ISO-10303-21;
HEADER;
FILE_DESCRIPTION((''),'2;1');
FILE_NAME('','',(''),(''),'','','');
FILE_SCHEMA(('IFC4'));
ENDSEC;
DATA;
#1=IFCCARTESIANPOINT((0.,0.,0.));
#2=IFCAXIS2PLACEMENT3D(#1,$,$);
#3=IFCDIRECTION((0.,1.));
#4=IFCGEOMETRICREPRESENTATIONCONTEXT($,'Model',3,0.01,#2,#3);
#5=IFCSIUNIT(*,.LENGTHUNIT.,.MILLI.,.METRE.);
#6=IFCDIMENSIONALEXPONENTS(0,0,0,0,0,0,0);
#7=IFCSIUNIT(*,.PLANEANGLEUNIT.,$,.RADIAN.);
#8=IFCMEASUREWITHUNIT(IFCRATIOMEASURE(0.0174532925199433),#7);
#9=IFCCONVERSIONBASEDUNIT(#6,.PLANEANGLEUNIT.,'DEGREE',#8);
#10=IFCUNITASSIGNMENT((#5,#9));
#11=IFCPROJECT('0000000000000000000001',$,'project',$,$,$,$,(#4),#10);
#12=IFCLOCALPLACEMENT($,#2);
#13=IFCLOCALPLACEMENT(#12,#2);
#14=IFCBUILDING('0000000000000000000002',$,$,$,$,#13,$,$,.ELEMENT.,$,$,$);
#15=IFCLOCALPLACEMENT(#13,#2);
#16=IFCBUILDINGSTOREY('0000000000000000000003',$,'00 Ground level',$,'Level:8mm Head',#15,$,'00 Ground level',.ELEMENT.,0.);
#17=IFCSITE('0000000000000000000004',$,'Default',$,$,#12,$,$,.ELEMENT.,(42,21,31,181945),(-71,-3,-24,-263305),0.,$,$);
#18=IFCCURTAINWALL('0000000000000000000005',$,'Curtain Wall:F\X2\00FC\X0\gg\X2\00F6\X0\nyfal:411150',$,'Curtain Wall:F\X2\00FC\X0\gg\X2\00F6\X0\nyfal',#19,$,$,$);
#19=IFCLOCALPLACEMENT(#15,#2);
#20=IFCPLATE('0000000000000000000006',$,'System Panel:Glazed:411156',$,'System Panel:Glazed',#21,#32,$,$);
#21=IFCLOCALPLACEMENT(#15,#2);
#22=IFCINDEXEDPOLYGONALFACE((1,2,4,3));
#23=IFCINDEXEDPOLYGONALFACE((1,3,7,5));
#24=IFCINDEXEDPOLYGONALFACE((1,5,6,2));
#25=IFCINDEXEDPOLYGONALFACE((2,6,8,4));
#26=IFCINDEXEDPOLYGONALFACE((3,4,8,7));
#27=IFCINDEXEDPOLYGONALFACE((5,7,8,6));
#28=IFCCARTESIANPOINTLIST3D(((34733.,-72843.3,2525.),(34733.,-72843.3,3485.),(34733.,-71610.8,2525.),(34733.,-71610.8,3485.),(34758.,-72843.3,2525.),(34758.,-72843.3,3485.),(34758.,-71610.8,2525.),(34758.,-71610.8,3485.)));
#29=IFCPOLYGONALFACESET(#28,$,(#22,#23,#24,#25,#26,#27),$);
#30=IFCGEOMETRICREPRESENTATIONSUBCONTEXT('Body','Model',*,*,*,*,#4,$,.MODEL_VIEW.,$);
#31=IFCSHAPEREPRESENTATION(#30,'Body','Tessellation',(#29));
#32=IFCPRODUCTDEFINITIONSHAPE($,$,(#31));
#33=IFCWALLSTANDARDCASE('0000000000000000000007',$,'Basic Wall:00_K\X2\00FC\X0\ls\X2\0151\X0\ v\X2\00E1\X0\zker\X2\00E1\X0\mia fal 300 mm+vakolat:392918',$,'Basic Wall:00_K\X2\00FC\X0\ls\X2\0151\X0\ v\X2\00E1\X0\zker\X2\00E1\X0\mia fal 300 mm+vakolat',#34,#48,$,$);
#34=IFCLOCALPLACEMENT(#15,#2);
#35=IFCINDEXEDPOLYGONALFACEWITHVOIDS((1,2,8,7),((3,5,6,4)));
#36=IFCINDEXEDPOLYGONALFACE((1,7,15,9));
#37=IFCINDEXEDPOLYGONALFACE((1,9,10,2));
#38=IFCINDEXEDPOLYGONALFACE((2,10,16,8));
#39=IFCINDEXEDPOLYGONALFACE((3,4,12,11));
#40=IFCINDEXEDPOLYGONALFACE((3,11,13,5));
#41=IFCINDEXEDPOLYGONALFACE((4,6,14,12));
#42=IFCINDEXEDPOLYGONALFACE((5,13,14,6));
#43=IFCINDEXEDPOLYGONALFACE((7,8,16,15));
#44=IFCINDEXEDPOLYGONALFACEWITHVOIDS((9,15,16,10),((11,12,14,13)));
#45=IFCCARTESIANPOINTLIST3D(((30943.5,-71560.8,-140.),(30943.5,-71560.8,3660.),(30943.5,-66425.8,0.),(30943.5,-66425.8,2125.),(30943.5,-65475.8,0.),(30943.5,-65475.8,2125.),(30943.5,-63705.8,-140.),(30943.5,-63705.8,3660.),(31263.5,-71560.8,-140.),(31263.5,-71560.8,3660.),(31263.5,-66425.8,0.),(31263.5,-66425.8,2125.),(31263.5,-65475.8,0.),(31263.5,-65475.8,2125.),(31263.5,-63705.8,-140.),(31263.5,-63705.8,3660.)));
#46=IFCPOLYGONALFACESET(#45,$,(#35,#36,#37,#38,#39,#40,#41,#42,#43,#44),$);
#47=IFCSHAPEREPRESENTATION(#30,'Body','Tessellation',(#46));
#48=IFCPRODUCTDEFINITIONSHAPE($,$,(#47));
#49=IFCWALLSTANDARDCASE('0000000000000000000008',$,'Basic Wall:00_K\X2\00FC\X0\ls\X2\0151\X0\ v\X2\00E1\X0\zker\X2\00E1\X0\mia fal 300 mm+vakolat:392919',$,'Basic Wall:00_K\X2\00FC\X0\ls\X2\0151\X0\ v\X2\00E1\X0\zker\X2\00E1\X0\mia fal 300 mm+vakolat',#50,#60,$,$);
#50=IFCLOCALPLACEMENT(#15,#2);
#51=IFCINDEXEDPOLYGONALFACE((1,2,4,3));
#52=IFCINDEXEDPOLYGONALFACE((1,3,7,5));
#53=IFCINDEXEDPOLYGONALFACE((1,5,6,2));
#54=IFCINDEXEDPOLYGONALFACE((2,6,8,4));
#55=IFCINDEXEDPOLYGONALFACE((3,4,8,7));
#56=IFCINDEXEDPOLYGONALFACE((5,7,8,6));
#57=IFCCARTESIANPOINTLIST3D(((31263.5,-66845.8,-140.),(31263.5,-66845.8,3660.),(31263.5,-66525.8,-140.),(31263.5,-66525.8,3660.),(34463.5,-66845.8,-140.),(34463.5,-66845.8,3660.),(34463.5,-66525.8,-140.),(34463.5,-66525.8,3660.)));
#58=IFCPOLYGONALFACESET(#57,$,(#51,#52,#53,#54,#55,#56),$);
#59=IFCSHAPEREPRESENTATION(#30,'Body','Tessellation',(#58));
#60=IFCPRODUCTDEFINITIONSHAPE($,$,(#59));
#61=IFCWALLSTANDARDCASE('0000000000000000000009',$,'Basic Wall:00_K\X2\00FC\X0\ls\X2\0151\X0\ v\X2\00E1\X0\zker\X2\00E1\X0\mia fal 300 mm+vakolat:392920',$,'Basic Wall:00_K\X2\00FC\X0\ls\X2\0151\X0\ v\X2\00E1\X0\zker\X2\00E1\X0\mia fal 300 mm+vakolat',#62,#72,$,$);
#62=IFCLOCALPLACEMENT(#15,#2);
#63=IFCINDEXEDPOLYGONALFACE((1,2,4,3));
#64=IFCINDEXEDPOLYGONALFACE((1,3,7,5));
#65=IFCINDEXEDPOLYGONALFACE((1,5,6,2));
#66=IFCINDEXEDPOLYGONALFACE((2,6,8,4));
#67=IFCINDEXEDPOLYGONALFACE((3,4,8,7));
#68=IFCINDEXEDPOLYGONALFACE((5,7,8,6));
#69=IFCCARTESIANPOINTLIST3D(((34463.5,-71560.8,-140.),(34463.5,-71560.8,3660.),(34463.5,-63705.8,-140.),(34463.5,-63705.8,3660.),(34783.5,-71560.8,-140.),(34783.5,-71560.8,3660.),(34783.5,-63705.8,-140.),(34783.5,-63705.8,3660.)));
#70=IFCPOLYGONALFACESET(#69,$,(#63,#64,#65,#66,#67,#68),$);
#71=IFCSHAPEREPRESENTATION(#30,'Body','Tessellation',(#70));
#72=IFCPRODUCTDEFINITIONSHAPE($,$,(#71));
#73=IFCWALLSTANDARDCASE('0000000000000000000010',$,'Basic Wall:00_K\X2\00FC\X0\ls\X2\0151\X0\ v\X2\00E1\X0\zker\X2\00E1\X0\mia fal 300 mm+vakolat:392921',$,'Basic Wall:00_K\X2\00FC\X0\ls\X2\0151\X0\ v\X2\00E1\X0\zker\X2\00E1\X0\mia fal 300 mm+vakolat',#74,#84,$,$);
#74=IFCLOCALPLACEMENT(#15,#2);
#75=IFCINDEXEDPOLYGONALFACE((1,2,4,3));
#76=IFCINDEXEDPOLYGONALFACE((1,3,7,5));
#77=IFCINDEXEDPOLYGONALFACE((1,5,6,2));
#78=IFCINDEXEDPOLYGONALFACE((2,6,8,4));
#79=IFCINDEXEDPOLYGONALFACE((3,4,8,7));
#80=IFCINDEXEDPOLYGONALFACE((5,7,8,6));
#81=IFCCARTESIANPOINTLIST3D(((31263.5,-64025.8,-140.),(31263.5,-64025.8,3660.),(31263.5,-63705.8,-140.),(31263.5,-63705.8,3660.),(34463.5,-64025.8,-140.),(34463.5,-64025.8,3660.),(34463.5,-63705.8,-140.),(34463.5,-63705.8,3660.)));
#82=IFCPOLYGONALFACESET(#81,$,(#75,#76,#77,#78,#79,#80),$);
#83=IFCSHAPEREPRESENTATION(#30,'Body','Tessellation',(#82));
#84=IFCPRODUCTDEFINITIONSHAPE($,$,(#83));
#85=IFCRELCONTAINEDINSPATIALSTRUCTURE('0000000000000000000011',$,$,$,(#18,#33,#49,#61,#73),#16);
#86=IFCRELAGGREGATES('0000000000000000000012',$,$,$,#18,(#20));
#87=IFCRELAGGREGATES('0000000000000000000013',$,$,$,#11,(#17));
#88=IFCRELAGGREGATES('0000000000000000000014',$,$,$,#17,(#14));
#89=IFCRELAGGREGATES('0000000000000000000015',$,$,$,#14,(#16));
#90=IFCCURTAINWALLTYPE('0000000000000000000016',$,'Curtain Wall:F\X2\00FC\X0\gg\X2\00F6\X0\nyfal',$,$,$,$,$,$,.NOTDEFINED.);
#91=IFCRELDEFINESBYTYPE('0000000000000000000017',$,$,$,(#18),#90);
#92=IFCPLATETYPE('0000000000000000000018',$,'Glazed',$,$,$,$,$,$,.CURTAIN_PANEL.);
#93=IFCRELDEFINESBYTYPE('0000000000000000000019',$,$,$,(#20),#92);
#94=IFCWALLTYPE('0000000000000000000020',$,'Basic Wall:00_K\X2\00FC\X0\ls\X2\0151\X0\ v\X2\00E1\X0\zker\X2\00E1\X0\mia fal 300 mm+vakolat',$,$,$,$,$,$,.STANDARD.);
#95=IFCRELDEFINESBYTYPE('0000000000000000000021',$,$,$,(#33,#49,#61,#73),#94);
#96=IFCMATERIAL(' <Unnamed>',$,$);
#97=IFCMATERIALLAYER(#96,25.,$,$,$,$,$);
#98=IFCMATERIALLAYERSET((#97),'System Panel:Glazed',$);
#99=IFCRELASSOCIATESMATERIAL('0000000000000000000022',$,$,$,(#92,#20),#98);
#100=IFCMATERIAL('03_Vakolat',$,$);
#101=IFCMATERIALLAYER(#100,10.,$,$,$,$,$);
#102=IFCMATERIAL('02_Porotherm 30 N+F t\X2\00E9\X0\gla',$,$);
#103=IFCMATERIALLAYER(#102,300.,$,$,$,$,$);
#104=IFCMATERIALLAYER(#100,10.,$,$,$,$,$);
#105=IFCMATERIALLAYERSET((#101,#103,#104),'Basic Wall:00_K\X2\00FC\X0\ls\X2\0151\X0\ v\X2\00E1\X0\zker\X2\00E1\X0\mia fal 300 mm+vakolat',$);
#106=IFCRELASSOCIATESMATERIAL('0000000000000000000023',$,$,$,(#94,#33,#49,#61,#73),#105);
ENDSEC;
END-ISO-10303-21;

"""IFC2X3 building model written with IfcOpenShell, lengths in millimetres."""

from ifc_helpers import new_model, entity, si_unit, converted_unit, direction, frame, frame_2d, origin, place, context, subcontext, project, spatial, rectangle, extrude, source, transform, mapped, material, layer, layer_set, layer_usage, type_object, type_shapes, element, aggregate, save


model = new_model("IFC2X3")

# Units and contexts
model_context = context("Model", 3, precision=0.01, world=origin(), true_north=direction((0.0, 1.0)))
body_context = subcontext(model_context, "Body", "Model", "MODEL_VIEW")
ifc_project = project(units=[si_unit("LENGTHUNIT", "METRE", prefix="MILLI"), converted_unit("PLANEANGLEUNIT", "DEGREE", entity("IfcRatioMeasure", 0.0174532925199433), si_unit("PLANEANGLEUNIT", "RADIAN"), dimensions=[0, 0, 0, 0, 0, 0, 0])], contexts=[model_context])

# Site, building, storey
site_placement = place(None, origin())
site = spatial("IfcSite", under=ifc_project, at=site_placement, Name="Default", CompositionType="ELEMENT", RefLatitude=(42, 21, 31, 181945), RefLongitude=(-71, -3, -24, -263305), RefElevation=0.0)
building_placement = place(site_placement, origin())
building = spatial("IfcBuilding", under=site, at=building_placement, CompositionType="ELEMENT")
storey_placement = place(building_placement, origin())
storey = spatial("IfcBuildingStorey", under=building, at=storey_placement, Name="00 Ground level", ObjectType="Level:8mm Head", LongName="00 Ground level", CompositionType="ELEMENT", Elevation=0.0)

# Shared definitions
curtain_wall_type = type_object("IfcCurtainWallType", Name="Curtain Wall:Függönyfal", PredefinedType="NOTDEFINED")

# Curtain wall
curtain_wall_1_placement = place(storey_placement, origin())
curtain_wall_1 = element("IfcCurtainWall", 1, at=curtain_wall_1_placement, inside=storey, type_object=curtain_wall_type, Name="Curtain Wall:Függönyfal:411150", ObjectType="Curtain Wall:Függönyfal")

# Plate
ifc_material_1 = material(Name=" <Unnamed>")
ifc_layer_1 = layer(ifc_material_1, 25.0)
ifc_layer_set_1 = layer_set([ifc_layer_1], Name="System Panel:Glazed")
ifc_layer_usage_1 = layer_usage(ifc_layer_set_1, "AXIS3", "POSITIVE", 0.1)
plate_type_1 = type_object("IfcPlateType", Name="Glazed", PredefinedType="CURTAIN_PANEL", material=ifc_layer_set_1)
shared_shape_1 = source(origin(), body_context, "Body", "SweptSolid", [
    extrude(rectangle(XDim=25.0, YDim=1232.5, at=frame_2d((0.0, 0.0), x_axis=(1.0, 0.0))), frame((616.2, 12.5, 0.0), z_axis=(0.0, 0.0, 1.0), x_axis=(0.0, 1.0, 0.0)), (0.0, 0.0, 1.0), 960.0),
])
type_shapes(plate_type_1, [shared_shape_1])
plate_1_placement = place(curtain_wall_1_placement, frame((34758.0, -72843.3, 2525.0), z_axis=(0.0, 0.0, 1.0), x_axis=(0.0, 1.0, 0.0)))
plate_1 = element("IfcPlate", 2, at=plate_1_placement, type_object=plate_type_1, material=ifc_layer_usage_1, Name="System Panel:Glazed:411156", ObjectType="System Panel:Glazed", context=body_context, shape_type="MappedRepresentation", body=[
    mapped(shared_shape_1, transform((0.0, 0.0, 0.0), scale=1.0)),
])
aggregate(curtain_wall_1, [plate_1])

# Wall, opening
ifc_material_2 = material(Name="03_Vakolat")
ifc_layer_2 = layer(ifc_material_2, 10.0)
ifc_material_3 = material(Name="02_Porotherm 30 N+F tégla")
ifc_layer_3 = layer(ifc_material_3, 300.0)
ifc_layer_4 = layer(ifc_material_2, 10.0)
ifc_layer_set_2 = layer_set([ifc_layer_2, ifc_layer_3, ifc_layer_4], Name="Basic Wall:00_Külső vázkerámia fal 300 mm+vakolat")
ifc_layer_usage_2 = layer_usage(ifc_layer_set_2, "AXIS2", "NEGATIVE", 160.0)
wall_type = type_object("IfcWallType", Name="Basic Wall:00_Külső vázkerámia fal 300 mm+vakolat", PredefinedType="STANDARD", material=ifc_layer_set_2)
wall_1_placement = place(storey_placement, frame((31103.5, -63705.8, -140.0), z_axis=(0.0, 0.0, 1.0), x_axis=(0.0, -1.0, 0.0)))
wall_1 = element("IfcWallStandardCase", 3, at=wall_1_placement, inside=storey, type_object=wall_type, material=ifc_layer_usage_2, Name="Basic Wall:00_Külső vázkerámia fal 300 mm+vakolat:392918", ObjectType="Basic Wall:00_Külső vázkerámia fal 300 mm+vakolat", context=body_context, shape_type="SweptSolid", body=[
    extrude(rectangle(XDim=7855.0, YDim=320.0, at=frame_2d((3927.5, 0.0), x_axis=(-1.0, 0.0))), origin(), (0.0, 0.0, 1.0), 3800.0),
])
opening_placement = place(wall_1_placement, frame((2720.0, -1684.0, 140.0), z_axis=(0.0, 0.0, 1.0), x_axis=(0.0, 1.0, 0.0)))
element("IfcOpeningElement", 4, at=opening_placement, cuts=wall_1, ObjectType="Opening", context=body_context, shape_type="SweptSolid", body=[
    extrude(rectangle(XDim=2125.0, YDim=950.0, at=frame_2d((0.0, 0.0), x_axis=(0.0, 1.0))), frame((0.0, 475.0, 1062.5), z_axis=(1.0, 0.0, 0.0), x_axis=(0.0, 1.0, 0.0)), (0.0, 0.0, 1.0), 3048.0),
])

# Walls
ifc_layer_usage_3 = layer_usage(ifc_layer_set_2, "AXIS2", "NEGATIVE", 160.0)
wall_2_placement = place(storey_placement, frame((31263.5, -66685.8, -140.0)))
element("IfcWallStandardCase", 5, at=wall_2_placement, inside=storey, type_object=wall_type, material=ifc_layer_usage_3, Name="Basic Wall:00_Külső vázkerámia fal 300 mm+vakolat:392919", ObjectType="Basic Wall:00_Külső vázkerámia fal 300 mm+vakolat", context=body_context, shape_type="SweptSolid", body=[
    extrude(rectangle(XDim=3200.0, YDim=320.0, at=frame_2d((1600.0, 0.0), x_axis=(-1.0, 0.0))), origin(), (0.0, 0.0, 1.0), 3800.0),
])
ifc_layer_usage_4 = layer_usage(ifc_layer_set_2, "AXIS2", "NEGATIVE", 160.0)
wall_3_placement = place(storey_placement, frame((34623.5, -63705.8, -140.0), z_axis=(0.0, 0.0, 1.0), x_axis=(0.0, -1.0, 0.0)))
element("IfcWallStandardCase", 6, at=wall_3_placement, inside=storey, type_object=wall_type, material=ifc_layer_usage_4, Name="Basic Wall:00_Külső vázkerámia fal 300 mm+vakolat:392920", ObjectType="Basic Wall:00_Külső vázkerámia fal 300 mm+vakolat", context=body_context, shape_type="SweptSolid", body=[
    extrude(rectangle(XDim=7855.0, YDim=320.0, at=frame_2d((3927.5, 0.0), x_axis=(-1.0, 0.0))), origin(), (0.0, 0.0, 1.0), 3800.0),
])
ifc_layer_usage_5 = layer_usage(ifc_layer_set_2, "AXIS2", "NEGATIVE", 160.0)
wall_4_placement = place(storey_placement, frame((31263.5, -63865.8, -140.0)))
element("IfcWallStandardCase", 7, at=wall_4_placement, inside=storey, type_object=wall_type, material=ifc_layer_usage_5, Name="Basic Wall:00_Külső vázkerámia fal 300 mm+vakolat:392921", ObjectType="Basic Wall:00_Külső vázkerámia fal 300 mm+vakolat", context=body_context, shape_type="SweptSolid", body=[
    extrude(rectangle(XDim=3200.0, YDim=320.0, at=frame_2d((1600.0, 0.0), x_axis=(-1.0, 0.0))), origin(), (0.0, 0.0, 1.0), 3800.0),
])

save(model, "model.ifc")
